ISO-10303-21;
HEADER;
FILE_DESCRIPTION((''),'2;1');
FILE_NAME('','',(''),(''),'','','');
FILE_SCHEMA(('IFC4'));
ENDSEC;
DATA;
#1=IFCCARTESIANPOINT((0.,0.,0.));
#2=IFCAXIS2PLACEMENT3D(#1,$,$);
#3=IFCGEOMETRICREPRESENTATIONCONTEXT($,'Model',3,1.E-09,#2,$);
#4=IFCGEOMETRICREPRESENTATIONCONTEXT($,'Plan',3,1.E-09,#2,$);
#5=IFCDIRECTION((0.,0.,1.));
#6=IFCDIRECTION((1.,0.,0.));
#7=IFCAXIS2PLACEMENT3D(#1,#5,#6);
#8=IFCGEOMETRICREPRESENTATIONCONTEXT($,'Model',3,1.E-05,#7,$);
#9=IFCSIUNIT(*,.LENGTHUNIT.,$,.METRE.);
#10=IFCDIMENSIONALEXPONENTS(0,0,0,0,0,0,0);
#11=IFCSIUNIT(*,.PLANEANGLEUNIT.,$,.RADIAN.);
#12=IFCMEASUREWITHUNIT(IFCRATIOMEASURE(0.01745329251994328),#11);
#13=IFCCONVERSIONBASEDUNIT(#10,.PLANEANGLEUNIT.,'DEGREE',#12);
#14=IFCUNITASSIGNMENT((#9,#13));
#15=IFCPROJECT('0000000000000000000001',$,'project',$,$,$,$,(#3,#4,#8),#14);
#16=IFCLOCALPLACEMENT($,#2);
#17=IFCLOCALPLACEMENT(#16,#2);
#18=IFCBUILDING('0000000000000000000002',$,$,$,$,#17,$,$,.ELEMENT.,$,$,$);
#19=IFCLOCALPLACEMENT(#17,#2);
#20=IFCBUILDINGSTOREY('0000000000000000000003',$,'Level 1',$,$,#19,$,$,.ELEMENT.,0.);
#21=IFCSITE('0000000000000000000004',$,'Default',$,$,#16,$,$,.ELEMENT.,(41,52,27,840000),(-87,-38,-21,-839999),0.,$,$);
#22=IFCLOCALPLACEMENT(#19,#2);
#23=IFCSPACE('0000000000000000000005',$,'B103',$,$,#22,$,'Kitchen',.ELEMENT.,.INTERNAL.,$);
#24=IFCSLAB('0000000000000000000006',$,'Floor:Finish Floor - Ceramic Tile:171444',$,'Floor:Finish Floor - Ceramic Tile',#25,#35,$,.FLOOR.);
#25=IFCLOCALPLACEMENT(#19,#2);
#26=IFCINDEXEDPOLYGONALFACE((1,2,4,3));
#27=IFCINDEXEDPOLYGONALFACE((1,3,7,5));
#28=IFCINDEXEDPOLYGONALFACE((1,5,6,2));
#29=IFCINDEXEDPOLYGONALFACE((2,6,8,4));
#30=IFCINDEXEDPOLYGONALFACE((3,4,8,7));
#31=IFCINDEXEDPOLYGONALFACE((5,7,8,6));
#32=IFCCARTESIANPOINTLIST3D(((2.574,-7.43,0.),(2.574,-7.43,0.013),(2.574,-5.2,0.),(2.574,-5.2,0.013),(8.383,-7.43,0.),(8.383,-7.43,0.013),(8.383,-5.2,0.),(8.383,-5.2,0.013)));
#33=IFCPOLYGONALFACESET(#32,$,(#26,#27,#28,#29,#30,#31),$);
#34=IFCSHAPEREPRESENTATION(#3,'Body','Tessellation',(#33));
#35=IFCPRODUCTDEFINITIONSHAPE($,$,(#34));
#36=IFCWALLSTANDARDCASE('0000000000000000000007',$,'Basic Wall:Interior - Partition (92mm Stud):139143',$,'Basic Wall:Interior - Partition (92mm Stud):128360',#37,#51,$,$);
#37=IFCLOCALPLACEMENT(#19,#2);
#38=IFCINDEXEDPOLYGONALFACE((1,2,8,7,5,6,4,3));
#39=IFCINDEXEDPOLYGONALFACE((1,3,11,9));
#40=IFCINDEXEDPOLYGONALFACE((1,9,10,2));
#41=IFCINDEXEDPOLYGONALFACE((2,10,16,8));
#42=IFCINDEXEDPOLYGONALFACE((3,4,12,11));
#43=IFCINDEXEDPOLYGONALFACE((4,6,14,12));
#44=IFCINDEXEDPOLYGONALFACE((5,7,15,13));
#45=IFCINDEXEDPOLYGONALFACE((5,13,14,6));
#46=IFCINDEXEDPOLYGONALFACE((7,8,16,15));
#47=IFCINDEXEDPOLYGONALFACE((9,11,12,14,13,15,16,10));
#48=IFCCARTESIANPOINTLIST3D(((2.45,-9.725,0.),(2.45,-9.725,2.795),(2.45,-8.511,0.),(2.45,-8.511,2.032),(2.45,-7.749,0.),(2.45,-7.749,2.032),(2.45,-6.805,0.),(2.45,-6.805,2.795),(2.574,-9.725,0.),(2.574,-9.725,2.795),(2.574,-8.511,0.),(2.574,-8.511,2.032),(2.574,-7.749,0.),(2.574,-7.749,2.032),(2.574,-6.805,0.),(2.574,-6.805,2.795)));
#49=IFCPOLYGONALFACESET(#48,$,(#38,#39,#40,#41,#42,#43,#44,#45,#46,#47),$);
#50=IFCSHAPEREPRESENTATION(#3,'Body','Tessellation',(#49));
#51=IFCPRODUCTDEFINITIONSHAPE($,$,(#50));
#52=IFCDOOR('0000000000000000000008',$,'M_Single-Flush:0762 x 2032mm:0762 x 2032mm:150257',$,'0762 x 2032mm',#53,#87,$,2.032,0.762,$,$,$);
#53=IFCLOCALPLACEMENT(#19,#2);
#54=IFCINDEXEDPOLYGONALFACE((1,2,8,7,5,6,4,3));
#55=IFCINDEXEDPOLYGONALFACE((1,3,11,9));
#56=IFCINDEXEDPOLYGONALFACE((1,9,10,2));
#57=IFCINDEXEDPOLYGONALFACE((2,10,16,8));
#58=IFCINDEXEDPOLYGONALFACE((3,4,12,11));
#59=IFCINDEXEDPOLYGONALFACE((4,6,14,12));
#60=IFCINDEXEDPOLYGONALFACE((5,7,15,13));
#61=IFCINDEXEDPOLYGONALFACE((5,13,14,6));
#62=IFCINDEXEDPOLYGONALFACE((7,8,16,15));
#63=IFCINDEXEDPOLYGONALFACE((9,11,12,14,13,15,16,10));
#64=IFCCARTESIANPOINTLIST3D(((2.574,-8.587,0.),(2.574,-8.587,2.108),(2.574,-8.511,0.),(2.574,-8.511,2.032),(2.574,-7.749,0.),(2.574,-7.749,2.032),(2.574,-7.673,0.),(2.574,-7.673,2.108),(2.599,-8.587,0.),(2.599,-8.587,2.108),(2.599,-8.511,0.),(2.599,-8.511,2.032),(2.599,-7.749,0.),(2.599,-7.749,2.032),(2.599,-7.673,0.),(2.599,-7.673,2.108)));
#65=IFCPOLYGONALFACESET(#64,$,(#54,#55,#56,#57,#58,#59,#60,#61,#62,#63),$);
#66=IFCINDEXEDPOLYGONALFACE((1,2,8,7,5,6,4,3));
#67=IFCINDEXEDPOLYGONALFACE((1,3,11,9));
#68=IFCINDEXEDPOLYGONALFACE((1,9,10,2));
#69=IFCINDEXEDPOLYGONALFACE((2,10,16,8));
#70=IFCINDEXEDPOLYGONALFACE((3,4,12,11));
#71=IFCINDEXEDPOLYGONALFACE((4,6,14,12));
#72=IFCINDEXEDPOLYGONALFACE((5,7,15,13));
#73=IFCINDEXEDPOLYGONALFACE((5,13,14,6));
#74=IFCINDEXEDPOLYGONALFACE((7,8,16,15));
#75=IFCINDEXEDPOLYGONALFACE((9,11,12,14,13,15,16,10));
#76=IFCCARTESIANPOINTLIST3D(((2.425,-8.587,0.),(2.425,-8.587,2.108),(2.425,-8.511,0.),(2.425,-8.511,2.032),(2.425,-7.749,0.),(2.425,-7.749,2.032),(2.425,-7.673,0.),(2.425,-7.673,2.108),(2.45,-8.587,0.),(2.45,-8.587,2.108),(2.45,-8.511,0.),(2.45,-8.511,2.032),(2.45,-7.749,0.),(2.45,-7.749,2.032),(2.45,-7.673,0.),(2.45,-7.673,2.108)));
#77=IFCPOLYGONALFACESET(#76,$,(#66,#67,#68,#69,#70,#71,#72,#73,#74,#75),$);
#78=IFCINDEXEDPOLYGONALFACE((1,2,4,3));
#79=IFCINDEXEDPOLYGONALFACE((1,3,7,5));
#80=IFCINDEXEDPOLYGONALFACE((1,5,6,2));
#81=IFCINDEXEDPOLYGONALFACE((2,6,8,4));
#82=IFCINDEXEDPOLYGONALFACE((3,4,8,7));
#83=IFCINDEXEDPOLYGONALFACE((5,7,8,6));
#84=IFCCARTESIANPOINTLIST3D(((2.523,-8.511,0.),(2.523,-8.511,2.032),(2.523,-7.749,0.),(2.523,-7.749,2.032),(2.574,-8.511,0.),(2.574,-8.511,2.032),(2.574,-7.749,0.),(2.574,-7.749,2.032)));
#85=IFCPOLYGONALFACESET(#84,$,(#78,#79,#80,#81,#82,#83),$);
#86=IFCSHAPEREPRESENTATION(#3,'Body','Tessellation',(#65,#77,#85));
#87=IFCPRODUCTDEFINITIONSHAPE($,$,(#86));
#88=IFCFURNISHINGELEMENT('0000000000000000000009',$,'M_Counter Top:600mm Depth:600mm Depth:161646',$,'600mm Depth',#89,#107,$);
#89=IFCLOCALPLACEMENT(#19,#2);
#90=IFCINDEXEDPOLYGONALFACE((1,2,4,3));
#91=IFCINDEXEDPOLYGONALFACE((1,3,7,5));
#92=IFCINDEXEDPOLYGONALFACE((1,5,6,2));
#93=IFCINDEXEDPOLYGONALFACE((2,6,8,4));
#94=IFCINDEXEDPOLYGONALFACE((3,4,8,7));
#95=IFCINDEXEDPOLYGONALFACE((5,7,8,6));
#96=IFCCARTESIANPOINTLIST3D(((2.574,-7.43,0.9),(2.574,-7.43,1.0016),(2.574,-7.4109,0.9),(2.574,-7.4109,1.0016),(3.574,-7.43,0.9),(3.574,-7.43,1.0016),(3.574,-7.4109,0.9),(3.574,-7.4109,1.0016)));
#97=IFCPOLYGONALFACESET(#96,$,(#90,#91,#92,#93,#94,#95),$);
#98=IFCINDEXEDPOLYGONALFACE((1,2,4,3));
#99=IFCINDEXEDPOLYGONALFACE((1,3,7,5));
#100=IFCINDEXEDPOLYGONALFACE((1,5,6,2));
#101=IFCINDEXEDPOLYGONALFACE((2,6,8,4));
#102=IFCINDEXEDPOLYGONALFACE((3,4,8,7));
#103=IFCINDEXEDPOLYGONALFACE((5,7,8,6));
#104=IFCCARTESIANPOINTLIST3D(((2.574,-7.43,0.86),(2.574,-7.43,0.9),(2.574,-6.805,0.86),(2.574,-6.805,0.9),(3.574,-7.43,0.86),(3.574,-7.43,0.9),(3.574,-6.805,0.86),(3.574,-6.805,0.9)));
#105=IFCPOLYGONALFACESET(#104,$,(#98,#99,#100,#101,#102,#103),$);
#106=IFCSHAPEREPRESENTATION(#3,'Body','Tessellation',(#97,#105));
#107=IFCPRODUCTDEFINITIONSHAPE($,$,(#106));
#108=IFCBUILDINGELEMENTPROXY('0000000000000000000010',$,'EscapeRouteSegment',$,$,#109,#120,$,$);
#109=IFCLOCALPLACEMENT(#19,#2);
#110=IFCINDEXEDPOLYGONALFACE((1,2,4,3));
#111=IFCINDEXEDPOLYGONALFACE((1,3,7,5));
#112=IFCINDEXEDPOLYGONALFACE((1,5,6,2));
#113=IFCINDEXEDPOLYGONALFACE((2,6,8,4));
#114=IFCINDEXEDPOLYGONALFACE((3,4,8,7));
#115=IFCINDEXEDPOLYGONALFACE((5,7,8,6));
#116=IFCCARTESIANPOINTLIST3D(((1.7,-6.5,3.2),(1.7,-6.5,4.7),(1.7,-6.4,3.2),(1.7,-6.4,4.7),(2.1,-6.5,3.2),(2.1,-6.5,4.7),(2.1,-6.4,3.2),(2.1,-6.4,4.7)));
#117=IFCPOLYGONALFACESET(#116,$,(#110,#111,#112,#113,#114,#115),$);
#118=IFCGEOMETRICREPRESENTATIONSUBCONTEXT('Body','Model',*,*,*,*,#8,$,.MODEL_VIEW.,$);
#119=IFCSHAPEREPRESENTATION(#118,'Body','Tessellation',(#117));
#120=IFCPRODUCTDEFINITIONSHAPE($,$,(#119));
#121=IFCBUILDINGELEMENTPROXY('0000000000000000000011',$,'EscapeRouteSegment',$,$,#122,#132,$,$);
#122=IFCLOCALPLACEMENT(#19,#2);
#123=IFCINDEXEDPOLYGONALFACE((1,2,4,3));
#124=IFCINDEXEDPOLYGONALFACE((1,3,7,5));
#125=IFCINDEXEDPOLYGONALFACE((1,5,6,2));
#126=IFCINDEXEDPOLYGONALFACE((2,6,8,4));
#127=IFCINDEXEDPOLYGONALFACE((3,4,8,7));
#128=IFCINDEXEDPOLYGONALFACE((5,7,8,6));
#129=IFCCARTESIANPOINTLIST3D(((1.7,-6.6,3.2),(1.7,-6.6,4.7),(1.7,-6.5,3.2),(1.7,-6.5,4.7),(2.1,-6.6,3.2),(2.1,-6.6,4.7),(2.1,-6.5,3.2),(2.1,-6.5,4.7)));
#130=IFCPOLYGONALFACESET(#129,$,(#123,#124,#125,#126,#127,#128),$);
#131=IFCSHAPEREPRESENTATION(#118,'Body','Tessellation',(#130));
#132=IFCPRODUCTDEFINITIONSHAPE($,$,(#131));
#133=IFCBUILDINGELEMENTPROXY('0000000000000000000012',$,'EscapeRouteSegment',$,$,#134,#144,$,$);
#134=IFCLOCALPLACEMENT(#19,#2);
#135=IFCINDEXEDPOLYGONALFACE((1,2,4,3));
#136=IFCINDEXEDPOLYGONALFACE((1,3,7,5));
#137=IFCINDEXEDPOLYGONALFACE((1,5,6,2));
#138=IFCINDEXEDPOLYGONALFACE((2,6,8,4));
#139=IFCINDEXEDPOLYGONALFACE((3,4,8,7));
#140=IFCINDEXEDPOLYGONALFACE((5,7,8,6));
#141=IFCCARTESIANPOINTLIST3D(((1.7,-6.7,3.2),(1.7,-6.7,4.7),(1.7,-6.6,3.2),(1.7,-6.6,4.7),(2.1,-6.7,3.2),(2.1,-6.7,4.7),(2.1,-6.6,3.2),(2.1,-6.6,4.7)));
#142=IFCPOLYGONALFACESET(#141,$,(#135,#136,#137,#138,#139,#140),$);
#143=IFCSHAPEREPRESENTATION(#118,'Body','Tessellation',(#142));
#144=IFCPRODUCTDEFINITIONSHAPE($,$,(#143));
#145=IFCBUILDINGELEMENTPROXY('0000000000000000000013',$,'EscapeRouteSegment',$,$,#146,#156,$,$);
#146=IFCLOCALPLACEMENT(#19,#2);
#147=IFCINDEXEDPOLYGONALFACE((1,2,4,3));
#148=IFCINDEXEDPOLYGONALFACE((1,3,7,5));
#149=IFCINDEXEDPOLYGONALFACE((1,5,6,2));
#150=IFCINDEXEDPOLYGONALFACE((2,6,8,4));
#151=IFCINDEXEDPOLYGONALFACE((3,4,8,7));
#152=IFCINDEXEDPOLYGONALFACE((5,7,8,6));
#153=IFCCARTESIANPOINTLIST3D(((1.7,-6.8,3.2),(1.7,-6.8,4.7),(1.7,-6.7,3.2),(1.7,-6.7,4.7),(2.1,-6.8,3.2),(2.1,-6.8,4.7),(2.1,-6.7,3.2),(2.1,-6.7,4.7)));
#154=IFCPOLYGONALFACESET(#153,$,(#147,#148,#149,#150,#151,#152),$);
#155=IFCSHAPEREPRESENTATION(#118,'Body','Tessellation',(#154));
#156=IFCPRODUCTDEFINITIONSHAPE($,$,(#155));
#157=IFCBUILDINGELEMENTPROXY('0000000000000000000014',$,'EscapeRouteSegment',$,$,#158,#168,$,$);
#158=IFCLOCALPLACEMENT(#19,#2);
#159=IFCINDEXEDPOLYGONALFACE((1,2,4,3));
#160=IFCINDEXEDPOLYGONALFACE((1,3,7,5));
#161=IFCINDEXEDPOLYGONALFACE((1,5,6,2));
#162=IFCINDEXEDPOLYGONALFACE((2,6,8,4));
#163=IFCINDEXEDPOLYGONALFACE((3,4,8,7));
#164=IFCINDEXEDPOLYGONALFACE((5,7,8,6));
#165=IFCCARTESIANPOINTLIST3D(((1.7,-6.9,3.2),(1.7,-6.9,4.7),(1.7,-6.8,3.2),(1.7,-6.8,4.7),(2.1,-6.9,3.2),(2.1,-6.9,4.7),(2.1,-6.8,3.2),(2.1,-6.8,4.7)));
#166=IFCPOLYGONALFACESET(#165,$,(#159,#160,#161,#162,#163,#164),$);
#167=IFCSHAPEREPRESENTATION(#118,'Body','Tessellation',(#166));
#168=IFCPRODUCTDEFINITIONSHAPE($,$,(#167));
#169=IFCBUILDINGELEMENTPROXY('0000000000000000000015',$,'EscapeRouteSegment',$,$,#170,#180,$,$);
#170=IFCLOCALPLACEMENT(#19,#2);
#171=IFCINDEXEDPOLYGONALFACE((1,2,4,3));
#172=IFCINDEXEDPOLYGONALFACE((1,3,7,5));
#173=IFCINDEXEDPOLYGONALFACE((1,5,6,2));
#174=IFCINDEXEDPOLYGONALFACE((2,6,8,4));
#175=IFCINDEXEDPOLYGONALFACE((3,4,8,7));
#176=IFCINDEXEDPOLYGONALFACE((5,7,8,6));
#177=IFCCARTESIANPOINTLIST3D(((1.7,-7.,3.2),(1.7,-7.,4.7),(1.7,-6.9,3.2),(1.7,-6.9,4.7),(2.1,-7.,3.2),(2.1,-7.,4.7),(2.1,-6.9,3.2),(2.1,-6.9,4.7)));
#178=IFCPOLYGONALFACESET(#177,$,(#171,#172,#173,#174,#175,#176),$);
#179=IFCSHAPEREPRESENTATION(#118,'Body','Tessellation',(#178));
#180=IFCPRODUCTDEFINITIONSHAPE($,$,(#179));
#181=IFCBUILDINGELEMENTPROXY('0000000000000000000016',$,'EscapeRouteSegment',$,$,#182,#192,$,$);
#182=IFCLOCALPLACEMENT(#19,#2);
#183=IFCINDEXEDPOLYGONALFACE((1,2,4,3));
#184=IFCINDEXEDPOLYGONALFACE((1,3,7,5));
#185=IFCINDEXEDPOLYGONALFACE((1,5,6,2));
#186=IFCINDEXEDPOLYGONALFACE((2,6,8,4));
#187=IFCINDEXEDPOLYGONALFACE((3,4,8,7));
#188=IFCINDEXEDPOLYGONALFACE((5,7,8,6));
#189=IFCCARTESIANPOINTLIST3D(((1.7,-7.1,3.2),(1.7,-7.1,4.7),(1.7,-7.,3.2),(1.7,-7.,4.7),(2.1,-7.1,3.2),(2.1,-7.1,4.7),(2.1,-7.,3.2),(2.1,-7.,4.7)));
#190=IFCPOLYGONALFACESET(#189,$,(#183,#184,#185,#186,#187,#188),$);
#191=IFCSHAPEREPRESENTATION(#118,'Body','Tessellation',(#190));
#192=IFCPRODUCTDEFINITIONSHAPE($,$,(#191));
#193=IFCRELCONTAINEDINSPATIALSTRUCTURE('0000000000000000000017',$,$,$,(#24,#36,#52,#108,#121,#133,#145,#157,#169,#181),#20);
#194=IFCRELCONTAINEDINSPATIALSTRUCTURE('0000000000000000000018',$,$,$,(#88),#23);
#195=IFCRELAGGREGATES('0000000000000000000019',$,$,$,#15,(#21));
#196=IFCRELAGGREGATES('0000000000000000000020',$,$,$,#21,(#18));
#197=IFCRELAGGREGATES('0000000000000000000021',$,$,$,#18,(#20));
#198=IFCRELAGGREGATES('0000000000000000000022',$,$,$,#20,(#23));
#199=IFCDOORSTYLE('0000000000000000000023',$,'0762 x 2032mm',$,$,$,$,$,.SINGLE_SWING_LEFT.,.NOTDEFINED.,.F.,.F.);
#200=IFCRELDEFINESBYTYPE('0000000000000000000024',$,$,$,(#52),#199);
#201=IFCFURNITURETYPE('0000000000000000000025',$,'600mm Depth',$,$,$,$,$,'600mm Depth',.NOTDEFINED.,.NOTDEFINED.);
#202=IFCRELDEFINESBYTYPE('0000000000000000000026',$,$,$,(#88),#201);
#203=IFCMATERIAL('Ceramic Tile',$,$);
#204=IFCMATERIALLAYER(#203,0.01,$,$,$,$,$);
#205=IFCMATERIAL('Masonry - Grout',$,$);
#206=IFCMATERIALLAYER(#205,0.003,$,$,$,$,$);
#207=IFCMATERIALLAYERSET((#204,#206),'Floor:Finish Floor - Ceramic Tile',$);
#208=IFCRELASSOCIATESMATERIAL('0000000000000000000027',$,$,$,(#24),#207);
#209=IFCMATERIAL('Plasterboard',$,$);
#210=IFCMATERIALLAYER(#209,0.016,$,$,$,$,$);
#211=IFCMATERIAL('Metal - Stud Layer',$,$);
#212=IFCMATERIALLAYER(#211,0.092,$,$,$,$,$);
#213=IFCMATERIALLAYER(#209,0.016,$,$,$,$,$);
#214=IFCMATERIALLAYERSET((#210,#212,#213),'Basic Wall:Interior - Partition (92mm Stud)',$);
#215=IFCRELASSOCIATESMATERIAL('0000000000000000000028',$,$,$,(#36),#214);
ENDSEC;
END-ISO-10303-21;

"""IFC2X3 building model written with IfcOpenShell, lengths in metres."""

from ifc_helpers import new_model, entity, si_unit, converted_unit, frame, frame_2d, origin, origin_with_axes, origin_2d_with_axis, place, context, subcontext, project, spatial, polyline, rectangle, outline, extrude, source, transform, mapped, material, layer, layer_set, layer_usage, type_object, type_shapes, element, fill, save


model = new_model("IFC2X3")

# Units and contexts
model_context_1 = context("Model", 3, precision=1e-09, world=origin())
plan_context = context("Plan", 3, precision=1e-09, world=origin())
model_context_2 = context("Model", 3, precision=1e-05, world=origin_with_axes())
body_context = subcontext(model_context_2, "Body", "Model", "MODEL_VIEW")
ifc_project = project(units=[si_unit("LENGTHUNIT", "METRE"), converted_unit("PLANEANGLEUNIT", "DEGREE", entity("IfcRatioMeasure", 0.01745329251994328), si_unit("PLANEANGLEUNIT", "RADIAN"), dimensions=[0, 0, 0, 0, 0, 0, 0])], contexts=[model_context_1, plan_context, model_context_2])

# Site, building, storey
site_placement = place(None, origin())
site = spatial("IfcSite", under=ifc_project, at=site_placement, Name="Default", CompositionType="ELEMENT", RefLatitude=(41, 52, 27, 840000), RefLongitude=(-87, -38, -21, -839999), RefElevation=0.0)
building_placement = place(site_placement, origin())
building = spatial("IfcBuilding", under=site, at=building_placement, CompositionType="ELEMENT")
storey_placement = place(building_placement, origin())
storey = spatial("IfcBuildingStorey", under=building, at=storey_placement, Name="Level 1", CompositionType="ELEMENT", Elevation=0.0)

# Slab
ifc_material_1 = material(Name="Ceramic Tile")
ifc_layer_1 = layer(ifc_material_1, 0.01)
ifc_material_2 = material(Name="Masonry - Grout")
ifc_layer_2 = layer(ifc_material_2, 0.003)
ifc_layer_set_1 = layer_set([ifc_layer_1, ifc_layer_2], Name="Floor:Finish Floor - Ceramic Tile")
ifc_layer_usage_1 = layer_usage(ifc_layer_set_1, "AXIS3", "POSITIVE", 0.0)
slab_placement = place(storey_placement, frame((2.574, -7.43, 0.0)))
element("IfcSlab", 1, at=slab_placement, inside=storey, material=ifc_layer_usage_1, Name="Floor:Finish Floor - Ceramic Tile:171444", ObjectType="Floor:Finish Floor - Ceramic Tile", PredefinedType="FLOOR", context=model_context_1, shape_type="SweptSolid", body=[
    extrude(rectangle(XDim=5.809, YDim=2.23, at=frame_2d((0.0, 0.0), x_axis=(-1.0, 0.0))), frame((2.9045, 1.115, 0.013), z_axis=(0.0, 0.0, -1.0), x_axis=(-1.0, 0.0, 0.0)), (0.0, 0.0, 1.0), 0.013),
])

# Wall, opening, door
ifc_material_3 = material(Name="Plasterboard")
ifc_layer_3 = layer(ifc_material_3, 0.016)
ifc_material_4 = material(Name="Metal - Stud Layer")
ifc_layer_4 = layer(ifc_material_4, 0.092)
ifc_layer_5 = layer(ifc_material_3, 0.016)
ifc_layer_set_2 = layer_set([ifc_layer_3, ifc_layer_4, ifc_layer_5], Name="Basic Wall:Interior - Partition (92mm Stud)")
ifc_layer_usage_2 = layer_usage(ifc_layer_set_2, "AXIS2", "NEGATIVE", 0.062)
wall_placement = place(storey_placement, frame((2.512, -6.805, 0.0), z_axis=(0.0, 0.0, 1.0), x_axis=(0.0, -1.0, 0.0)))
wall = element("IfcWallStandardCase", 2, at=wall_placement, inside=storey, material=ifc_layer_usage_2, Name="Basic Wall:Interior - Partition (92mm Stud):139143", ObjectType="Basic Wall:Interior - Partition (92mm Stud):128360", context=model_context_1, shape_type="SweptSolid", body=[
    extrude(rectangle(XDim=2.92, YDim=0.124, at=frame_2d((1.46, 0.0), x_axis=(-1.0, 0.0))), origin(), (0.0, 0.0, 1.0), 2.795),
])
opening_placement = place(wall_placement, frame((0.944, -0.062, 0.0)))
opening = element("IfcOpeningElement", 3, at=opening_placement, cuts=wall, ObjectType="Opening", context=model_context_1, shape_type="SweptSolid", body=[
    extrude(rectangle(XDim=0.762, YDim=2.032, at=frame_2d((1.016, 0.381), x_axis=(0.0, -1.0))), frame((0.0, 0.0, 0.0), z_axis=(0.0, 1.0, 0.0), x_axis=(0.0, 0.0, 1.0)), (0.0, 0.0, 1.0), 0.124),
])
door_style = type_object("IfcDoorStyle", Name="0762 x 2032mm", ConstructionType="NOTDEFINED", OperationType="SINGLE_SWING_LEFT", ParameterTakesPrecedence=False, Sizeable=False)
shared_shape_1 = source(origin(), model_context_1, "Body", "SweptSolid", [
    extrude(outline(polyline([(-0.457, -1.073), (0.457, -1.073), (0.457, 1.035), (0.381, 1.035), (0.381, -0.997), (-0.381, -0.997), (-0.381, 1.035), (-0.457, 1.035), (-0.457, -1.073)])), frame((0.381, 0.149, 1.035), z_axis=(0.0, -1.0, 0.0), x_axis=(-1.0, 0.0, 0.0)), (0.0, 0.0, 1.0), 0.025),
    extrude(outline(polyline([(-1.073, -0.457), (1.035, -0.457), (1.035, -0.381), (-0.997, -0.381), (-0.997, 0.381), (1.035, 0.381), (1.035, 0.457), (-1.073, 0.457), (-1.073, -0.457)])), frame((0.381, 0.0, 1.035), z_axis=(0.0, -1.0, 0.0), x_axis=(0.0, 0.0, -1.0)), (0.0, 0.0, 1.0), 0.025),
    extrude(rectangle(XDim=0.762, YDim=0.051, at=origin_2d_with_axis()), frame((0.381, 0.0985, 0.0)), (0.0, 0.0, 1.0), 2.032),
])
type_shapes(door_style, [shared_shape_1])
door_placement = place(opening_placement, origin())
door = element("IfcDoor", 4, at=door_placement, inside=storey, type_object=door_style, Name="M_Single-Flush:0762 x 2032mm:0762 x 2032mm:150257", ObjectType="0762 x 2032mm", OverallHeight=2.032, OverallWidth=0.762, context=model_context_1, shape_type="MappedRepresentation", body=[
    mapped(shared_shape_1, transform((0.0, 0.0, 0.0), scale=1.0)),
])
fill(opening, door)

# Shared definitions
space_placement = place(storey_placement, origin())
space = spatial("IfcSpace", under=storey, at=space_placement, Name="B103", LongName="Kitchen", CompositionType="ELEMENT", InteriorOrExteriorSpace="INTERNAL")

# Furnishing element
furniture_type = type_object("IfcFurnitureType", Name="600mm Depth", ElementType="600mm Depth", AssemblyPlace="NOTDEFINED")
shared_shape_2 = source(origin(), model_context_1, "Body", "SweptSolid", [
    extrude(rectangle(XDim=0.0191, YDim=1.0, at=origin_2d_with_axis()), frame((-0.7005, -0.0095, 0.9), z_axis=(0.0, 0.0, 1.0), x_axis=(0.0, -1.0, 0.0)), (0.0, 0.0, 1.0), 0.1016),
    extrude(rectangle(XDim=1.0, YDim=0.625, at=origin_2d_with_axis()), frame((-0.7005, -0.3125, 0.86), z_axis=(0.0, 0.0, 1.0), x_axis=(-1.0, 0.0, 0.0)), (0.0, 0.0, 1.0), 0.04),
])
type_shapes(furniture_type, [shared_shape_2])
furnishing_placement = place(space_placement, frame((2.3735, -7.43, 0.0), z_axis=(0.0, 0.0, 1.0), x_axis=(-1.0, 0.0, 0.0)))
element("IfcFurnishingElement", 5, at=furnishing_placement, inside=space, type_object=furniture_type, Name="M_Counter Top:600mm Depth:600mm Depth:161646", ObjectType="600mm Depth", context=model_context_1, shape_type="MappedRepresentation", body=[
    mapped(shared_shape_2, transform((0.0, 0.0, 0.0), scale=1.0)),
])

# Building element proxies
for number, where, z_axis, x_axis, name in (
    (6, (1.9, -6.4, 3.2), (0.0, 0.0, 1.0), (0.0, -1.0, 0.0), "EscapeRouteSegment"),
    (7, (1.9, -6.5, 3.2), (0.0, 0.0, 1.0), (0.0, -1.0, 0.0), "EscapeRouteSegment"),
    (8, (1.9, -6.6, 3.2), (0.0, 0.0, 1.0), (0.0, -1.0, 0.0), "EscapeRouteSegment"),
):
    element("IfcBuildingElementProxy", number, at=place(storey_placement, frame(where, z_axis=z_axis, x_axis=x_axis)), inside=storey, Name=name, context=body_context, shape_type="SweptSolid", body=[
        extrude(outline(polyline([(0.0, -0.2), (0.0, 0.2), (0.1, 0.2), (0.1, -0.2), (0.0, -0.2)])), origin_with_axes(), (0.0, 0.0, 1.0), 1.5),
    ])
proxy_1_placement = place(storey_placement, frame((1.9, -6.7, 3.2), z_axis=(0.0, 0.0, 1.0), x_axis=(0.0, -1.0, 0.0)))
element("IfcBuildingElementProxy", 9, at=proxy_1_placement, inside=storey, Name="EscapeRouteSegment", context=body_context, shape_type="SweptSolid", body=[
    extrude(outline(polyline([(0.0, -0.2), (0.0, 0.2), (0.1, 0.2), (0.1, -0.2), (0.0, -0.2)])), origin_with_axes(), (0.0, 0.0, 1.0), 1.5),
])
for number, where, z_axis, x_axis, name in (
    (10, (1.9, -6.8, 3.2), (0.0, 0.0, 1.0), (0.0, -1.0, 0.0), "EscapeRouteSegment"),
    (11, (1.9, -6.9, 3.2), (0.0, 0.0, 1.0), (0.0, -1.0, 0.0), "EscapeRouteSegment"),
    (12, (1.9, -7.0, 3.2), (0.0, 0.0, 1.0), (0.0, -1.0, 0.0), "EscapeRouteSegment"),
):
    element("IfcBuildingElementProxy", number, at=place(storey_placement, frame(where, z_axis=z_axis, x_axis=x_axis)), inside=storey, Name=name, context=body_context, shape_type="SweptSolid", body=[
        extrude(outline(polyline([(0.0, -0.2), (0.0, 0.2), (0.1, 0.2), (0.1, -0.2), (0.0, -0.2)])), origin_with_axes(), (0.0, 0.0, 1.0), 1.5),
    ])

save(model, "model.ifc")
